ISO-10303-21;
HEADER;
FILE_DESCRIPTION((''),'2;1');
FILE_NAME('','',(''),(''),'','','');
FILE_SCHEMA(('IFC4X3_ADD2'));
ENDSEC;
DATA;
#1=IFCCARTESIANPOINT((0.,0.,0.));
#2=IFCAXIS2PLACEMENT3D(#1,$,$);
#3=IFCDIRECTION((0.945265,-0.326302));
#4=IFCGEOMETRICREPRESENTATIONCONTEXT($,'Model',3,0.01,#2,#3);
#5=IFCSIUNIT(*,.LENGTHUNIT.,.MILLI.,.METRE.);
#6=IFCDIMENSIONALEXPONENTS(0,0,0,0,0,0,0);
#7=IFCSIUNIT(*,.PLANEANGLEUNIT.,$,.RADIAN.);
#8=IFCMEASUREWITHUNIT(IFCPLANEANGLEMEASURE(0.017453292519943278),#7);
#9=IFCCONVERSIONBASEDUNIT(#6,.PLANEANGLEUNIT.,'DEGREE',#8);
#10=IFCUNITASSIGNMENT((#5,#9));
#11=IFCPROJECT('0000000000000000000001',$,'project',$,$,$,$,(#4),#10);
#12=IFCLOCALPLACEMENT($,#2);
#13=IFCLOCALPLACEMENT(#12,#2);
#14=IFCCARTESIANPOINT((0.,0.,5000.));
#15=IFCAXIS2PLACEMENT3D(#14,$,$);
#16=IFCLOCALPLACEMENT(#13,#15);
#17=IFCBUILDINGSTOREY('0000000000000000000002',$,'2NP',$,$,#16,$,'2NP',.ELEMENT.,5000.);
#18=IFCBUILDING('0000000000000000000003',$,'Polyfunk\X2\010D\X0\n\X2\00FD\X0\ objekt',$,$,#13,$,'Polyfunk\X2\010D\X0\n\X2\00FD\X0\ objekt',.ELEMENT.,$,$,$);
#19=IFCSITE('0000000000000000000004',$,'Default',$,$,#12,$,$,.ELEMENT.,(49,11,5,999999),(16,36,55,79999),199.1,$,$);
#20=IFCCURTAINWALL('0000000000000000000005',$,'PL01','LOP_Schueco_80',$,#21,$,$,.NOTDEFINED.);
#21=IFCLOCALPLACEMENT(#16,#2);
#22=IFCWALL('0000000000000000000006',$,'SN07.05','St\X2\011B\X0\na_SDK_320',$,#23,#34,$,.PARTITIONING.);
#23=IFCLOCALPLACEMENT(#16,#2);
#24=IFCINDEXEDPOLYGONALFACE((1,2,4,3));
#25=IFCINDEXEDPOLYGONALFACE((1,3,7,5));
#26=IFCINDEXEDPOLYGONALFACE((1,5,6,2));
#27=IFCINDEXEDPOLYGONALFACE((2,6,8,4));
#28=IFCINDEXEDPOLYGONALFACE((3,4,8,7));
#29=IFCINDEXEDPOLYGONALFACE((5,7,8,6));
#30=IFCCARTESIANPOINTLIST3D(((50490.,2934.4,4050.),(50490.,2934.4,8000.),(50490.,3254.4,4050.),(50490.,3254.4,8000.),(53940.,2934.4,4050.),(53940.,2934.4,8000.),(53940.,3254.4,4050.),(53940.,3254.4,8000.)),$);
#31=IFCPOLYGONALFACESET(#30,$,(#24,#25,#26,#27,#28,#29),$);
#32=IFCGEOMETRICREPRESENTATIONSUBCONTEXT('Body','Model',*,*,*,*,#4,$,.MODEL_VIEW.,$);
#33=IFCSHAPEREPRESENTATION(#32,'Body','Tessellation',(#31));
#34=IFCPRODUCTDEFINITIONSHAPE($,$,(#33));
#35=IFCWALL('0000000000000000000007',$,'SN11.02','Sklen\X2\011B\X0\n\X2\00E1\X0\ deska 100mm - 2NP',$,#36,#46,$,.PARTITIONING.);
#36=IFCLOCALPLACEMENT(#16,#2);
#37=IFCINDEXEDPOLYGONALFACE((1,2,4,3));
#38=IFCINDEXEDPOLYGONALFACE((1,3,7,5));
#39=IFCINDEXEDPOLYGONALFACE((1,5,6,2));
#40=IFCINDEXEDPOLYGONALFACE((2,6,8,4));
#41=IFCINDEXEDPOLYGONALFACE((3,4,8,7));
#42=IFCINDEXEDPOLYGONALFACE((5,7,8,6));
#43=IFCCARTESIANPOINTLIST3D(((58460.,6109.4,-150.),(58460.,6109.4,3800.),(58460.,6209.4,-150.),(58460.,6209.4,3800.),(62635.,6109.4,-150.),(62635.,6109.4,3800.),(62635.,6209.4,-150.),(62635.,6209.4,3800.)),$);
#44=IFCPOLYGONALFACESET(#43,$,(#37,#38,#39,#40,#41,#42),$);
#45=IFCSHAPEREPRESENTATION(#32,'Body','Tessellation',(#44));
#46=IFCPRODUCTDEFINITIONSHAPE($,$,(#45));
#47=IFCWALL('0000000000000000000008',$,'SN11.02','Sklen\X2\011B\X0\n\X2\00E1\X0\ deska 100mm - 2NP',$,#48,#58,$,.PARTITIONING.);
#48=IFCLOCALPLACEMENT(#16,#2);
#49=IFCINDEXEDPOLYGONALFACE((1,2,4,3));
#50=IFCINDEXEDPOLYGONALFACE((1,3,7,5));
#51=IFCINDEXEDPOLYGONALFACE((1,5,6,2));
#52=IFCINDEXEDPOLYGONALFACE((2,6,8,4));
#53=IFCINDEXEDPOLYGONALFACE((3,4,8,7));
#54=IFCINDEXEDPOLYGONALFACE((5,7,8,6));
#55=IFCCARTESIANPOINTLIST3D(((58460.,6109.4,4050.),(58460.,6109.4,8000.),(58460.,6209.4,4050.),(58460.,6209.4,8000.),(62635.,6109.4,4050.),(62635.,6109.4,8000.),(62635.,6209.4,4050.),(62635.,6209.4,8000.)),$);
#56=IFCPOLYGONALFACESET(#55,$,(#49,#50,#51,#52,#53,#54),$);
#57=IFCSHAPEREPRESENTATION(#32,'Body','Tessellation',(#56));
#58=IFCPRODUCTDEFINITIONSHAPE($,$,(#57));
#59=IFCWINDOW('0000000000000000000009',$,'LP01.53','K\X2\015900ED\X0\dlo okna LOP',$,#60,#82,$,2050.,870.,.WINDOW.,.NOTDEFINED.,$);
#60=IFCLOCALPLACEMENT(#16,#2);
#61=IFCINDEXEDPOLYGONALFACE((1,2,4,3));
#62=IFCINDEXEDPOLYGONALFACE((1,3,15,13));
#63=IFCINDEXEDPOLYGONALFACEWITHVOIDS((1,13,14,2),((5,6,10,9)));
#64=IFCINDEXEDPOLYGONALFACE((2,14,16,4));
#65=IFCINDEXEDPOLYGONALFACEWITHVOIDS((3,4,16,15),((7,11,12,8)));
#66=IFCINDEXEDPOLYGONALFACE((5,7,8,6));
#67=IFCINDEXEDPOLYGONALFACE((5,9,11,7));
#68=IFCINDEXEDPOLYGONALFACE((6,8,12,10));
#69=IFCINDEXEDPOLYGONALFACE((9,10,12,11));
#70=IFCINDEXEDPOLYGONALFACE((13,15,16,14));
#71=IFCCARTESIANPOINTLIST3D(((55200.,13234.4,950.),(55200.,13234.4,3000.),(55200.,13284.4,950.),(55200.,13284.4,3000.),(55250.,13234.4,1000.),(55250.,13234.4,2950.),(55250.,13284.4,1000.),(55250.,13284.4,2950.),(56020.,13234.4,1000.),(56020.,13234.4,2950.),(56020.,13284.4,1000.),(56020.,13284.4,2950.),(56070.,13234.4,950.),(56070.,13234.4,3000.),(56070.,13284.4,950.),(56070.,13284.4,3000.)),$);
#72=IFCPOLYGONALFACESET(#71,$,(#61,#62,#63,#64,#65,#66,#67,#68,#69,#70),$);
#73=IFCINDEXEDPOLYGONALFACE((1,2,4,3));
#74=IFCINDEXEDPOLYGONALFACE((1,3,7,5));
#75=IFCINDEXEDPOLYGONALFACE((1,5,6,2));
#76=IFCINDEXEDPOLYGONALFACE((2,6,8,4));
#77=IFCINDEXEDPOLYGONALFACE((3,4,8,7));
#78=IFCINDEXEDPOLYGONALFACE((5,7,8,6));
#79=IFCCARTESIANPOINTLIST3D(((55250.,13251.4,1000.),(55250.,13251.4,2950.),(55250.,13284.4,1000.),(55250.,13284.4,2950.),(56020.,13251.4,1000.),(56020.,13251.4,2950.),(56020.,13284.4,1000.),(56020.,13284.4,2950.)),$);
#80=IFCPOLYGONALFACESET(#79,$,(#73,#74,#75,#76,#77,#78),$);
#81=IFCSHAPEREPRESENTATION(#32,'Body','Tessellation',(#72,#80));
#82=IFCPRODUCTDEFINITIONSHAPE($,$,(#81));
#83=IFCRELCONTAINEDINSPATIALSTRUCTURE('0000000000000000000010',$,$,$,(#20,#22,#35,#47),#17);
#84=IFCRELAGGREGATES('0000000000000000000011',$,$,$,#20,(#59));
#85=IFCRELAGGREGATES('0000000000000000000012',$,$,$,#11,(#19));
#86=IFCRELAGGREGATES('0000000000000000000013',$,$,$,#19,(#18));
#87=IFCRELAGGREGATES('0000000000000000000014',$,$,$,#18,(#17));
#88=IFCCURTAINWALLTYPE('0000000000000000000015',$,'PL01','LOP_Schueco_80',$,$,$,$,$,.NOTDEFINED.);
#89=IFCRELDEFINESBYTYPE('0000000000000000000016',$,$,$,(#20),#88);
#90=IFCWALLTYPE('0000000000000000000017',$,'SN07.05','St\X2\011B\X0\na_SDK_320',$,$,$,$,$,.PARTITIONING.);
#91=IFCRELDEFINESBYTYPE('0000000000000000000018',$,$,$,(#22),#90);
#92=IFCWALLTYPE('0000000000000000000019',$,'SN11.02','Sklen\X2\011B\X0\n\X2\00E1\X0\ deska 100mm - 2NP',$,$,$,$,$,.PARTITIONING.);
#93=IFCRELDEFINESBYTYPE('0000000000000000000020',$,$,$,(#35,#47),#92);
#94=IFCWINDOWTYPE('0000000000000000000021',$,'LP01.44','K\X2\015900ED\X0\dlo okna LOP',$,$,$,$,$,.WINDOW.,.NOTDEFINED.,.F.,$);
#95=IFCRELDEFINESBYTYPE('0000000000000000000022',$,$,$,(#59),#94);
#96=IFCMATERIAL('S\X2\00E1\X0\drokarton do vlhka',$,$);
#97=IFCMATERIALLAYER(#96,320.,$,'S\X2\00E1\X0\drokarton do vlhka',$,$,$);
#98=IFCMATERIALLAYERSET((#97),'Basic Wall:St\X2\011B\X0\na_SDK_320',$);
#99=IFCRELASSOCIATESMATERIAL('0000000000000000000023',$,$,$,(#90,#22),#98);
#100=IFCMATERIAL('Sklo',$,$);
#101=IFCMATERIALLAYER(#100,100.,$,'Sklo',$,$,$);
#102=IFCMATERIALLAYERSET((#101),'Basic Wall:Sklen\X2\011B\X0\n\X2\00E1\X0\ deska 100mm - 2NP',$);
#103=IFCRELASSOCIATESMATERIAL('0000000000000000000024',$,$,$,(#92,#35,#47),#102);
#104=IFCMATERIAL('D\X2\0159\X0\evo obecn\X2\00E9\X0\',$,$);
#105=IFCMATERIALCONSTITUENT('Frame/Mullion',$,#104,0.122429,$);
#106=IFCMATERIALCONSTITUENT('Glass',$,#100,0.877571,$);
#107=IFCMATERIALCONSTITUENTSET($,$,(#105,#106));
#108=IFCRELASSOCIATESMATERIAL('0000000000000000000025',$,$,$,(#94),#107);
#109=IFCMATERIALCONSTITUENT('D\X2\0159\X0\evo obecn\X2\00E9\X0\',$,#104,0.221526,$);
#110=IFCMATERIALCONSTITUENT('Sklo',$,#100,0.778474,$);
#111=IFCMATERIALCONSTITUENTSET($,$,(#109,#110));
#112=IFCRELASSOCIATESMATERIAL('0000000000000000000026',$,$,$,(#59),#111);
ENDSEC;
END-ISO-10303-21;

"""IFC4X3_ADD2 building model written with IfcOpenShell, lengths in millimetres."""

from ifc_helpers import new_model, entity, si_unit, converted_unit, direction, frame, frame_2d, origin, origin_2d_with_axis, place, context, subcontext, project, spatial, polyline, rectangle, outline, extrude, clip, bounded_halfspace, source, transform, mapped, material, layer, layer_set, constituent, constituent_set, type_object, type_shapes, element, aggregate, save


model = new_model("IFC4X3_ADD2")

# Units and contexts
model_context = context("Model", 3, precision=0.01, world=origin(), true_north=direction((0.945265, -0.326302)))
body_context = subcontext(model_context, "Body", "Model", "MODEL_VIEW")
ifc_project = project(units=[si_unit("LENGTHUNIT", "METRE", prefix="MILLI"), converted_unit("PLANEANGLEUNIT", "DEGREE", entity("IfcPlaneAngleMeasure", 0.017453292519943278), si_unit("PLANEANGLEUNIT", "RADIAN"), dimensions=[0, 0, 0, 0, 0, 0, 0])], contexts=[model_context])

# Site, building, storey
site_placement = place(None, origin())
site = spatial("IfcSite", under=ifc_project, at=site_placement, Name="Default", CompositionType="ELEMENT", RefLatitude=(49, 11, 5, 999999), RefLongitude=(16, 36, 55, 79999), RefElevation=199.1)
building_placement = place(site_placement, origin())
building = spatial("IfcBuilding", under=site, at=building_placement, Name="Polyfunkčný objekt", LongName="Polyfunkčný objekt", CompositionType="ELEMENT")
storey_placement = place(building_placement, frame((0.0, 0.0, 5000.0)))
storey = spatial("IfcBuildingStorey", under=building, at=storey_placement, Name="2NP", LongName="2NP", CompositionType="ELEMENT", Elevation=5000.0)

# Curtain wall
curtain_wall_type = type_object("IfcCurtainWallType", Name="PL01", Description="LOP_Schueco_80", PredefinedType="NOTDEFINED")
curtain_wall_placement = place(storey_placement, frame((0.0, 0.0, -5000.0)))
curtain_wall = element("IfcCurtainWall", 1, at=curtain_wall_placement, inside=storey, type_object=curtain_wall_type, Name="PL01", Description="LOP_Schueco_80", PredefinedType="NOTDEFINED")
ifc_material_1 = material(Name="Sklo")

# Walls
ifc_material_2 = material(Name="Sádrokarton do vlhka")
ifc_layer_1 = layer(ifc_material_2, 320.0, Name="Sádrokarton do vlhka")
ifc_layer_set_1 = layer_set([ifc_layer_1], Name="Basic Wall:Stěna_SDK_320")
wall_type_1 = type_object("IfcWallType", Name="SN07.05", Description="Stěna_SDK_320", PredefinedType="PARTITIONING", material=ifc_layer_set_1)
wall_1_placement = place(storey_placement, frame((53940.0, 3094.4, 4050.0), z_axis=(0.0, 0.0, 1.0), x_axis=(-1.0, 0.0, 0.0)))
element("IfcWall", 2, at=wall_1_placement, inside=storey, type_object=wall_type_1, material=ifc_layer_set_1, Name="SN07.05", Description="Stěna_SDK_320", PredefinedType="PARTITIONING", context=body_context, shape_type="Clipping", body=[
    clip(clip(extrude(rectangle(XDim=3450.0, YDim=320.0, at=frame_2d((1725.0, 0.0), x_axis=(-1.0, 0.0))), origin(), (0.0, 0.0, 1.0), 3950.0), bounded_halfspace(frame((3450.0, -160.0, 0.0)), True, frame((3450.0, -160.0, 0.0)), polyline([(0.0, 0.0), (0.0, 320.0), (-1650.0, 320.0), (-1800.0, 320.0), (-3450.0, 320.0), (-3450.0, 0.0), (-1800.0, 0.0), (-1650.0, 0.0), (0.0, 0.0)]))), bounded_halfspace(frame((0.0, -160.0, 3950.0), z_axis=(0.0, 0.0, -1.0), x_axis=(-1.0, 0.0, 0.0)), True, frame((0.0, -160.0, 3950.0)), polyline([(0.0, 0.0), (1650.0, 0.0), (1800.0, 0.0), (3450.0, 0.0), (3450.0, 320.0), (1800.0, 320.0), (1650.0, 320.0), (0.0, 320.0), (0.0, 0.0)]))),
])
ifc_layer_2 = layer(ifc_material_1, 100.0, Name="Sklo")
ifc_layer_set_2 = layer_set([ifc_layer_2], Name="Basic Wall:Skleněná deska 100mm - 2NP")
wall_type_2 = type_object("IfcWallType", Name="SN11.02", Description="Skleněná deska 100mm - 2NP", PredefinedType="PARTITIONING", material=ifc_layer_set_2)
wall_2_placement = place(storey_placement, frame((58460.0, 6159.4, -150.0)))
element("IfcWall", 3, at=wall_2_placement, inside=storey, type_object=wall_type_2, material=ifc_layer_set_2, Name="SN11.02", Description="Skleněná deska 100mm - 2NP", PredefinedType="PARTITIONING", context=body_context, shape_type="Clipping", body=[
    clip(clip(extrude(rectangle(XDim=4175.0, YDim=100.0, at=frame_2d((2087.5, 0.0), x_axis=(-1.0, 0.0))), origin(), (0.0, 0.0, 1.0), 3950.0), bounded_halfspace(frame((4175.0, -50.0, 0.0), z_axis=(0.0, 0.0, 1.0), x_axis=(-1.0, 0.0, 0.0)), True, frame((4175.0, -50.0, 0.0)), polyline([(0.0, 0.0), (0.0, 100.0), (-4175.0, 100.0), (-4175.0, 0.0), (-4075.0, 0.0), (0.0, 0.0)]))), bounded_halfspace(frame((0.0, -50.0, 3950.0), z_axis=(0.0, 0.0, -1.0), x_axis=(1.0, 0.0, 0.0)), True, frame((0.0, -50.0, 3950.0)), polyline([(0.0, 0.0), (100.0, 0.0), (4175.0, 0.0), (4175.0, 100.0), (0.0, 100.0), (0.0, 0.0)]))),
])
wall_3_placement = place(storey_placement, frame((58460.0, 6159.4, 4050.0)))
element("IfcWall", 4, at=wall_3_placement, inside=storey, type_object=wall_type_2, material=ifc_layer_set_2, Name="SN11.02", Description="Skleněná deska 100mm - 2NP", PredefinedType="PARTITIONING", context=body_context, shape_type="Clipping", body=[
    clip(clip(extrude(rectangle(XDim=4175.0, YDim=100.0, at=frame_2d((2087.5, 0.0), x_axis=(-1.0, 0.0))), origin(), (0.0, 0.0, 1.0), 3950.0), bounded_halfspace(frame((4175.0, -50.0, 0.0), z_axis=(0.0, 0.0, 1.0), x_axis=(-1.0, 0.0, 0.0)), True, frame((4175.0, -50.0, 0.0)), polyline([(0.0, 0.0), (0.0, 100.0), (-4175.0, 100.0), (-4175.0, 0.0), (-4075.0, 0.0), (0.0, 0.0)]))), bounded_halfspace(frame((0.0, -50.0, 3950.0), z_axis=(0.0, 0.0, -1.0), x_axis=(1.0, 0.0, 0.0)), True, frame((0.0, -50.0, 3950.0)), polyline([(0.0, 0.0), (100.0, 0.0), (4175.0, 0.0), (4175.0, 100.0), (0.0, 100.0), (0.0, 0.0)]))),
])

# Window
ifc_material_3 = material(Name="Dřevo obecné")
ifc_constituent_1 = constituent(ifc_material_3, Name="Dřevo obecné", fraction=0.221526)
ifc_constituent_2 = constituent(ifc_material_1, Name="Sklo", fraction=0.778474)
ifc_constituent_set_1 = constituent_set(constituents=[ifc_constituent_1, ifc_constituent_2])
ifc_constituent_3 = constituent(ifc_material_3, Name="Frame/Mullion", fraction=0.122429)
ifc_constituent_4 = constituent(ifc_material_1, Name="Glass", fraction=0.877571)
ifc_constituent_set_2 = constituent_set(constituents=[ifc_constituent_3, ifc_constituent_4])
window_type = type_object("IfcWindowType", Name="LP01.44", Description="Křídlo okna LOP", ParameterTakesPrecedence=False, PartitioningType="NOTDEFINED", PredefinedType="WINDOW", material=ifc_constituent_set_2)
shared_shape_1 = source(origin(), body_context, "Body", "SweptSolid", [
    extrude(outline(polyline([(-1025.0, -435.0), (1025.0, -435.0), (1025.0, 435.0), (-1025.0, 435.0), (-1025.0, -435.0)]), holes=[polyline([(-975.0, -385.0), (-975.0, 385.0), (975.0, 385.0), (975.0, -385.0), (-975.0, -385.0)])]), frame((0.0, 0.0, 1025.0), z_axis=(0.0, 1.0, 0.0), x_axis=(0.0, 0.0, -1.0)), (0.0, 0.0, 1.0), 50.0),
    extrude(rectangle(XDim=33.0, YDim=770.0, at=origin_2d_with_axis()), frame((0.0, 33.5, 50.0), z_axis=(0.0, 0.0, 1.0), x_axis=(0.0, -1.0, 0.0)), (0.0, 0.0, 1.0), 1950.0),
])
type_shapes(window_type, [shared_shape_1])
window_placement = place(curtain_wall_placement, frame((55635.0, 13234.4, 5950.0)))
window = element("IfcWindow", 5, at=window_placement, type_object=window_type, material=ifc_constituent_set_1, Name="LP01.53", Description="Křídlo okna LOP", OverallHeight=2050.0, OverallWidth=870.0, PartitioningType="NOTDEFINED", PredefinedType="WINDOW", context=body_context, shape_type="MappedRepresentation", body=[
    mapped(shared_shape_1, transform((0.0, 0.0, 0.0), scale=1.0)),
])
aggregate(curtain_wall, [window])

save(model, "model.ifc")
